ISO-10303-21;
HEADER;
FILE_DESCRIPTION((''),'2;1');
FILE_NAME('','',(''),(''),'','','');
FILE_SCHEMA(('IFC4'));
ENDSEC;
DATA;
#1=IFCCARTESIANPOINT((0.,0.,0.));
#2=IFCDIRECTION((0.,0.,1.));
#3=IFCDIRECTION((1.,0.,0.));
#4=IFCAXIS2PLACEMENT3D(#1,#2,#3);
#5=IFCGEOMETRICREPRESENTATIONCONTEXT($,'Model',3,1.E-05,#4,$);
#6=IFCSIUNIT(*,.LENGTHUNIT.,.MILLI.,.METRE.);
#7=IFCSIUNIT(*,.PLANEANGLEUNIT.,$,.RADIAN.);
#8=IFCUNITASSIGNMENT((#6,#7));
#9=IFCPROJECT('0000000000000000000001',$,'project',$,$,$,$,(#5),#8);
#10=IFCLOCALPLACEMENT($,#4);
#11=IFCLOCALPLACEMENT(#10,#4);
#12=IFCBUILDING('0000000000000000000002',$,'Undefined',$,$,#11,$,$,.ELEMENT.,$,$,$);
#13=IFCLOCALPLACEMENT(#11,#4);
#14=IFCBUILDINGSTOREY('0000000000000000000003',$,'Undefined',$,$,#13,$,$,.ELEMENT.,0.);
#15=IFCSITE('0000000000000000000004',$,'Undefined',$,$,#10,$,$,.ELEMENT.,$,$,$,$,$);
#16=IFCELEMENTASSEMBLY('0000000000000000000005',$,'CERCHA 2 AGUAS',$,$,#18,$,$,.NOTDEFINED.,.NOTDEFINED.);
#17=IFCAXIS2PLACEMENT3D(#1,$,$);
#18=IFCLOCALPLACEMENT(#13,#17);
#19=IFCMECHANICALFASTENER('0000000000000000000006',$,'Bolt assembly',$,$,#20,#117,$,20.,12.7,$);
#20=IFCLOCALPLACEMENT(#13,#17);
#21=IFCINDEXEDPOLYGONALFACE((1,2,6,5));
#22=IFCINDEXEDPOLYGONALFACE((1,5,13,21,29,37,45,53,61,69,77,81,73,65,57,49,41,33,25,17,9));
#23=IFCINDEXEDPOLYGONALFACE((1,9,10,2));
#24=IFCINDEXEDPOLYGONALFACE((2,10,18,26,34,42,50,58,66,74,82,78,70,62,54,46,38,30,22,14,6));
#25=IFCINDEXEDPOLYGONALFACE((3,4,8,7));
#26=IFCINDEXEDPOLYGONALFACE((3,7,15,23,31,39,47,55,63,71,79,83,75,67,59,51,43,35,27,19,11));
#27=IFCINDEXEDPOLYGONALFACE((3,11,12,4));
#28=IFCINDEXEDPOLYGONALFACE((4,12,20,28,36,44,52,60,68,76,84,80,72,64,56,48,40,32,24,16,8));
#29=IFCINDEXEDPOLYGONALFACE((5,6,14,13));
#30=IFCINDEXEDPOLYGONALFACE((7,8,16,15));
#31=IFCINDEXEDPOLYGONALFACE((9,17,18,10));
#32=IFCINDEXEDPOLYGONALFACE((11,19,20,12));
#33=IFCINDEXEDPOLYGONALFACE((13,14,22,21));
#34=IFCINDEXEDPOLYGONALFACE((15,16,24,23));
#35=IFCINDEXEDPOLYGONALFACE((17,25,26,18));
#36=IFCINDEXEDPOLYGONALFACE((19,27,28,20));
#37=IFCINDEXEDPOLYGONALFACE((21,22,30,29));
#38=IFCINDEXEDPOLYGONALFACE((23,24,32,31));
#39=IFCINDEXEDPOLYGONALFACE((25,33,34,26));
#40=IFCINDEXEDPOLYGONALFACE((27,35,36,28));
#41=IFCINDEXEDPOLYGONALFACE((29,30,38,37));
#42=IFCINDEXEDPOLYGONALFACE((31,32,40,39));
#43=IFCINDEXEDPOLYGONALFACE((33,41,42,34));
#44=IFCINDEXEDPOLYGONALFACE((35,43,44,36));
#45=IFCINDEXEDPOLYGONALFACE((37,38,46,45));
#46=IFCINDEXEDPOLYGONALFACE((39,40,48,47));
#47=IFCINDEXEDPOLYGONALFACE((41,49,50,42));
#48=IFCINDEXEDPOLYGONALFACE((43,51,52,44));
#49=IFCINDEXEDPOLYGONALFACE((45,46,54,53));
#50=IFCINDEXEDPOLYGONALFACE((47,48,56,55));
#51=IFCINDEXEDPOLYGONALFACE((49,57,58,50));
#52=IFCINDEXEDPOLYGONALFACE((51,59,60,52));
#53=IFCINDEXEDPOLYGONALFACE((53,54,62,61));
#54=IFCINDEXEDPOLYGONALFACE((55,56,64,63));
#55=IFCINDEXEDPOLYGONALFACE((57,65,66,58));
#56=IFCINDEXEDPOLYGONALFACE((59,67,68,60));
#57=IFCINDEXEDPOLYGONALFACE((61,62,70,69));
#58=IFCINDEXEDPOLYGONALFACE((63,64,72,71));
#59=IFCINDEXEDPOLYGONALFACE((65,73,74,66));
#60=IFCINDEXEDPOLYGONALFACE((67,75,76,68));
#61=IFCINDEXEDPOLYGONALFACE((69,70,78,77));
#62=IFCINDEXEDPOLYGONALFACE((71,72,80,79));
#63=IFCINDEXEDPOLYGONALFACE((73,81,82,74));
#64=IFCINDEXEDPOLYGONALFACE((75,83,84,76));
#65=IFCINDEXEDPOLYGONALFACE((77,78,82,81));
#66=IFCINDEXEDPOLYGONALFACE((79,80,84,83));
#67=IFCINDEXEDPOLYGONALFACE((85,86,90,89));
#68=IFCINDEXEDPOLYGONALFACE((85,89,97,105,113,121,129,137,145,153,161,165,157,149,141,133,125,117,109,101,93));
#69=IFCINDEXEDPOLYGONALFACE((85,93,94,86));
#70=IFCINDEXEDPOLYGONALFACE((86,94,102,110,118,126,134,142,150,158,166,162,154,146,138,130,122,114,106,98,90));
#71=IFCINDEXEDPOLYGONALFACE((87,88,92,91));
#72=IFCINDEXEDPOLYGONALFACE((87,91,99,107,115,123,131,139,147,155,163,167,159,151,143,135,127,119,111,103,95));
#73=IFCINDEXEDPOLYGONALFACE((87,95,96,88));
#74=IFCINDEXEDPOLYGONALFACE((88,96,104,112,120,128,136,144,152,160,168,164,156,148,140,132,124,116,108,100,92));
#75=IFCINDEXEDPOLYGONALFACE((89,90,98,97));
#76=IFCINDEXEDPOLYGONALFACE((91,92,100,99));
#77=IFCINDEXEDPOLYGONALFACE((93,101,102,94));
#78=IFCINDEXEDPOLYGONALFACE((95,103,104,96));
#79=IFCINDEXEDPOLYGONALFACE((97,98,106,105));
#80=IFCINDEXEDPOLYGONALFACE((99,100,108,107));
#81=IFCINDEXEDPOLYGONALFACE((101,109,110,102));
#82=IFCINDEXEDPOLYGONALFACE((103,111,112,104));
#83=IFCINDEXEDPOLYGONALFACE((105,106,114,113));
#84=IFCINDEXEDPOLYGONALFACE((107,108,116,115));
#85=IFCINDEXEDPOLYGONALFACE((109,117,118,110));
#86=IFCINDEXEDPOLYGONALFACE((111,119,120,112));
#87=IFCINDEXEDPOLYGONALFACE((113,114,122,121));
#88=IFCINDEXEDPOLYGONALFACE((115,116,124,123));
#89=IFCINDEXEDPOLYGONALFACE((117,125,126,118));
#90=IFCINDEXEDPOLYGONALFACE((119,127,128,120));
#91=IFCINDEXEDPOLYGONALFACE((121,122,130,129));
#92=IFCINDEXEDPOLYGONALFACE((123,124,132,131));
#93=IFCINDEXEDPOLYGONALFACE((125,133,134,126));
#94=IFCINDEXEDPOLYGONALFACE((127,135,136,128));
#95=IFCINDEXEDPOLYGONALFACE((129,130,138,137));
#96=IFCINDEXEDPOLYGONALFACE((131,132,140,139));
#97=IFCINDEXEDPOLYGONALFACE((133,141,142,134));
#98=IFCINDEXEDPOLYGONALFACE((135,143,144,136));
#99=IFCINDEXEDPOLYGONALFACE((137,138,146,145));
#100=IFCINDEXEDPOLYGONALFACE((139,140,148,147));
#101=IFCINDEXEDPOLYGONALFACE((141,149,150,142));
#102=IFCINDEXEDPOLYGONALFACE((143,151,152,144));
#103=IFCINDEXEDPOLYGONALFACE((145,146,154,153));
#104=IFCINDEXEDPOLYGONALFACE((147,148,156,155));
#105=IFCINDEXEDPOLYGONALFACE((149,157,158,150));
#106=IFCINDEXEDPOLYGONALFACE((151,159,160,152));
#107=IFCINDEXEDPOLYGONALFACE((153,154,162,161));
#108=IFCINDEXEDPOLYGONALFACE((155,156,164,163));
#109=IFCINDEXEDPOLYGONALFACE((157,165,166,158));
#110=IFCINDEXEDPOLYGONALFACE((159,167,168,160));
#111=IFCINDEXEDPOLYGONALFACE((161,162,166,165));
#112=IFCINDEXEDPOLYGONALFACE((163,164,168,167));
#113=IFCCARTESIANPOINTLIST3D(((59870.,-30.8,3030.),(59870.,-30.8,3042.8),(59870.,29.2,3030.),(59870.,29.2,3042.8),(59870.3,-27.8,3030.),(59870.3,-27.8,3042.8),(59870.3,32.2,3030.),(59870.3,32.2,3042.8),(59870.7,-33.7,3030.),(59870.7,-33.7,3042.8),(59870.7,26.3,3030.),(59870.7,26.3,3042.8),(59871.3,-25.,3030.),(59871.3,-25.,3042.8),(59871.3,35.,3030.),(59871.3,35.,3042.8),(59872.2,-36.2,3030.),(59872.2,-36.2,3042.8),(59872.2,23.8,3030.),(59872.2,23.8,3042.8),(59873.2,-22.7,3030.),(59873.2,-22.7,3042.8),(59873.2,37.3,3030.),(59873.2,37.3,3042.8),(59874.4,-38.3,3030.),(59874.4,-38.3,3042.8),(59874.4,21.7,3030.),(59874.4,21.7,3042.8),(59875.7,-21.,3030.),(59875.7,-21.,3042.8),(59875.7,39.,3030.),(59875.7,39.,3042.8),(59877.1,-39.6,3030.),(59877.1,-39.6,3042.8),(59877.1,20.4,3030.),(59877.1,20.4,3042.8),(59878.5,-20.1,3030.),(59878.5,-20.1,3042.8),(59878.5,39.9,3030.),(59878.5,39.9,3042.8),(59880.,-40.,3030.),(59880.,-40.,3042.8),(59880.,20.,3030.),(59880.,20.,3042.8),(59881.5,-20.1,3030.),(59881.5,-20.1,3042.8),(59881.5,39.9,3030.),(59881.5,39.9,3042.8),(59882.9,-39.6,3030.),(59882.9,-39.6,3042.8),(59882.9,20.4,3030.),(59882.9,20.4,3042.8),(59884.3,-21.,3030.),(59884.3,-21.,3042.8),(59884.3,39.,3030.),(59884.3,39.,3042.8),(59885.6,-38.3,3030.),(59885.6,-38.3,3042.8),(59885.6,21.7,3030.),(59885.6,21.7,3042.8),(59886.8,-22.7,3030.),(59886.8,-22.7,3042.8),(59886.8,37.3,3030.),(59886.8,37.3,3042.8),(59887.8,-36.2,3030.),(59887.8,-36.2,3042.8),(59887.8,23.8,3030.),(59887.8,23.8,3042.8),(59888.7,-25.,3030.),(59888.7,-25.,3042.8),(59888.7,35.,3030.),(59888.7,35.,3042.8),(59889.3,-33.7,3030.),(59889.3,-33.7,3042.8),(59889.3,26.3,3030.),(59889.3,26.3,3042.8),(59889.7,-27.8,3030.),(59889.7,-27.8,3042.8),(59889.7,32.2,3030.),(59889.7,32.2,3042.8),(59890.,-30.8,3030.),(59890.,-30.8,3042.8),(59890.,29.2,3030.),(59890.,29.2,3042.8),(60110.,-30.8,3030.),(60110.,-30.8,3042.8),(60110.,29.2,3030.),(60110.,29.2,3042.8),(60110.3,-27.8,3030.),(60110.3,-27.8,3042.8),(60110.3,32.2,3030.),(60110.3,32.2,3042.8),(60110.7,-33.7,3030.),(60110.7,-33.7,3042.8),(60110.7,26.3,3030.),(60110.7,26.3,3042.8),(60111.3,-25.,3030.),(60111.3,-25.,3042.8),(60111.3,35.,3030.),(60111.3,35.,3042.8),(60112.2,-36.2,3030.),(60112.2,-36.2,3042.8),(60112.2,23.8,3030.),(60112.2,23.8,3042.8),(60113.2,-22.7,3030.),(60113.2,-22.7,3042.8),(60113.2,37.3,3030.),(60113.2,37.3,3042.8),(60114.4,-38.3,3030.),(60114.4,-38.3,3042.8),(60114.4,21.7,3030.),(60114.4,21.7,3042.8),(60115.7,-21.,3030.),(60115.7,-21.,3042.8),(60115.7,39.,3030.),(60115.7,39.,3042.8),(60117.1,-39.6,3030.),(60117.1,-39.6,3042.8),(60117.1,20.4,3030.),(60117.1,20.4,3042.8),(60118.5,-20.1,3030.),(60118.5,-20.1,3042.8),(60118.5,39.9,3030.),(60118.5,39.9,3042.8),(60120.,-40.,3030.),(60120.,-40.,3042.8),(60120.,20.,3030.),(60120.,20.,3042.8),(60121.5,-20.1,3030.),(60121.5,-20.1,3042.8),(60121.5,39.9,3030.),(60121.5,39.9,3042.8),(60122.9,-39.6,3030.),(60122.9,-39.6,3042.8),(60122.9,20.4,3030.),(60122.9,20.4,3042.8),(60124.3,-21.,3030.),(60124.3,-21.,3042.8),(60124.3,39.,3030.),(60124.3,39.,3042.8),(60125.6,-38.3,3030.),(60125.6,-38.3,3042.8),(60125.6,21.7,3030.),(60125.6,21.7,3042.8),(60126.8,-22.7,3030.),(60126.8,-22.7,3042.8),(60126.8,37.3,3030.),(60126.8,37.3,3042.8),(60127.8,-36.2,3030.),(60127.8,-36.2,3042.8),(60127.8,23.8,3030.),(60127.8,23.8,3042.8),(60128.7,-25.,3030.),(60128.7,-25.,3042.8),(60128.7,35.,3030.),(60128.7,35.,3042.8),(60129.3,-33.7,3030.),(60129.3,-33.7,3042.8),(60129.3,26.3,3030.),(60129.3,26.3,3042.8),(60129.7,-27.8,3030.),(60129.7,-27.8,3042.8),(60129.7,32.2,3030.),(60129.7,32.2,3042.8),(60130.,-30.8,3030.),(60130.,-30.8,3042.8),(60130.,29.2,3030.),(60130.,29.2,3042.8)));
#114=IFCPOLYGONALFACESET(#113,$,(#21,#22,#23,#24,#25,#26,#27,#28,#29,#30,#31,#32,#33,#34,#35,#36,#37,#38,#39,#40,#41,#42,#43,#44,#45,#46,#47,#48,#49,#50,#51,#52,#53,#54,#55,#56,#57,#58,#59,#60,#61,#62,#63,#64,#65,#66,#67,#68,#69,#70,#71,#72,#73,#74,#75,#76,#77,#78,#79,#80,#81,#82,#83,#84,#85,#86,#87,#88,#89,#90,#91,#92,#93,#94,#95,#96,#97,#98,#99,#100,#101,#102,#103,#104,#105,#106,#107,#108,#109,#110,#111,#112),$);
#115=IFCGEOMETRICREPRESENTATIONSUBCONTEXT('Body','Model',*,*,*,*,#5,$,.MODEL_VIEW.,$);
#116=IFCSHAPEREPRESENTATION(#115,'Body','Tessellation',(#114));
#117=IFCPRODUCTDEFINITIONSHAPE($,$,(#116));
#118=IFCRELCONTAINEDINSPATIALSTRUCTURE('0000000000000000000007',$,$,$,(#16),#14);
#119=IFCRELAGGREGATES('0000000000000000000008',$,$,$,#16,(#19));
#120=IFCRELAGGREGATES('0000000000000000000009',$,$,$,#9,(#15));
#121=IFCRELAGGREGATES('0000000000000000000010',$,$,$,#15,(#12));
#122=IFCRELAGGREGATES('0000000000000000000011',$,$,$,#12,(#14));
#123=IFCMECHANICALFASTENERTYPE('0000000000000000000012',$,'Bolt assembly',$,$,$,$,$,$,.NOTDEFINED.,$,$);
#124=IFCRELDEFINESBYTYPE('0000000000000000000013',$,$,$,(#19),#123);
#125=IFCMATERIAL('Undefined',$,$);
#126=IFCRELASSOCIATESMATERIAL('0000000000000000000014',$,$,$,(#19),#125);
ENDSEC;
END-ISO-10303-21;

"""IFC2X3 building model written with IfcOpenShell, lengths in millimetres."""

from ifc_helpers import new_model, si_unit, frame, origin_with_axes, origin_2d_with_axis, place, context, subcontext, project, spatial, circle, extrude, source, transform, mapped, material, type_object, element, aggregate, save


model = new_model("IFC2X3")

# Units and contexts
model_context = context("Model", 3, precision=1e-05, world=origin_with_axes())
body_context = subcontext(model_context, "Body", "Model", "MODEL_VIEW")
ifc_project = project(units=[si_unit("LENGTHUNIT", "METRE", prefix="MILLI"), si_unit("PLANEANGLEUNIT", "RADIAN")], contexts=[model_context])

# Site, building, storey
site_placement = place(None, origin_with_axes())
site = spatial("IfcSite", under=ifc_project, at=site_placement, Name="Undefined", CompositionType="ELEMENT")
building_placement = place(site_placement, origin_with_axes())
building = spatial("IfcBuilding", under=site, at=building_placement, Name="Undefined", CompositionType="ELEMENT")
storey_placement = place(building_placement, origin_with_axes())
storey = spatial("IfcBuildingStorey", under=building, at=storey_placement, Name="Undefined", CompositionType="ELEMENT", Elevation=0.0)

# Element assembly
assembly_1_placement = place(storey_placement, origin_with_axes())
assembly_1 = element("IfcElementAssembly", 1, at=assembly_1_placement, inside=storey, Name="CERCHA 2 AGUAS", AssemblyPlace="NOTDEFINED", PredefinedType="NOTDEFINED")

# Shared definitions
ifc_material_1 = material(Name="Undefined")
mechanical_fastener_type = type_object("IfcMechanicalFastenerType", Name="Bolt assembly")

# Mechanical fastener
shared_shape_1 = source(origin_with_axes(), body_context, "Body", "SweptSolid", [
    extrude(circle(Radius=10.0, at=origin_2d_with_axis()), frame((0.0, -12.7, 0.0), z_axis=(0.0, 1.0, 0.0), x_axis=(1.0, 0.0, 0.0)), (0.0, 0.0, 1.0), 12.8),
])
mechanical_fastener_1_placement = place(assembly_1_placement, frame((60000.0, 30.0, 3042.7), z_axis=(-1.0, 0.0, 0.0), x_axis=(0.0, -1.0, 0.0)))
mechanical_fastener_1 = element("IfcMechanicalFastener", 2, at=mechanical_fastener_1_placement, type_object=mechanical_fastener_type, material=ifc_material_1, Name="Bolt assembly", NominalDiameter=20.0, NominalLength=12.7, context=body_context, shape_type="MappedRepresentation", body=[
    mapped(shared_shape_1, transform((0.0, 0.0, -120.0))),
    mapped(shared_shape_1, transform((60.0, 0.0, -120.0))),
    mapped(shared_shape_1, transform((0.0, 0.0, 120.0))),
    mapped(shared_shape_1, transform((60.0, 0.0, 120.0))),
])
aggregate(assembly_1, [mechanical_fastener_1])

save(model, "model.ifc")
